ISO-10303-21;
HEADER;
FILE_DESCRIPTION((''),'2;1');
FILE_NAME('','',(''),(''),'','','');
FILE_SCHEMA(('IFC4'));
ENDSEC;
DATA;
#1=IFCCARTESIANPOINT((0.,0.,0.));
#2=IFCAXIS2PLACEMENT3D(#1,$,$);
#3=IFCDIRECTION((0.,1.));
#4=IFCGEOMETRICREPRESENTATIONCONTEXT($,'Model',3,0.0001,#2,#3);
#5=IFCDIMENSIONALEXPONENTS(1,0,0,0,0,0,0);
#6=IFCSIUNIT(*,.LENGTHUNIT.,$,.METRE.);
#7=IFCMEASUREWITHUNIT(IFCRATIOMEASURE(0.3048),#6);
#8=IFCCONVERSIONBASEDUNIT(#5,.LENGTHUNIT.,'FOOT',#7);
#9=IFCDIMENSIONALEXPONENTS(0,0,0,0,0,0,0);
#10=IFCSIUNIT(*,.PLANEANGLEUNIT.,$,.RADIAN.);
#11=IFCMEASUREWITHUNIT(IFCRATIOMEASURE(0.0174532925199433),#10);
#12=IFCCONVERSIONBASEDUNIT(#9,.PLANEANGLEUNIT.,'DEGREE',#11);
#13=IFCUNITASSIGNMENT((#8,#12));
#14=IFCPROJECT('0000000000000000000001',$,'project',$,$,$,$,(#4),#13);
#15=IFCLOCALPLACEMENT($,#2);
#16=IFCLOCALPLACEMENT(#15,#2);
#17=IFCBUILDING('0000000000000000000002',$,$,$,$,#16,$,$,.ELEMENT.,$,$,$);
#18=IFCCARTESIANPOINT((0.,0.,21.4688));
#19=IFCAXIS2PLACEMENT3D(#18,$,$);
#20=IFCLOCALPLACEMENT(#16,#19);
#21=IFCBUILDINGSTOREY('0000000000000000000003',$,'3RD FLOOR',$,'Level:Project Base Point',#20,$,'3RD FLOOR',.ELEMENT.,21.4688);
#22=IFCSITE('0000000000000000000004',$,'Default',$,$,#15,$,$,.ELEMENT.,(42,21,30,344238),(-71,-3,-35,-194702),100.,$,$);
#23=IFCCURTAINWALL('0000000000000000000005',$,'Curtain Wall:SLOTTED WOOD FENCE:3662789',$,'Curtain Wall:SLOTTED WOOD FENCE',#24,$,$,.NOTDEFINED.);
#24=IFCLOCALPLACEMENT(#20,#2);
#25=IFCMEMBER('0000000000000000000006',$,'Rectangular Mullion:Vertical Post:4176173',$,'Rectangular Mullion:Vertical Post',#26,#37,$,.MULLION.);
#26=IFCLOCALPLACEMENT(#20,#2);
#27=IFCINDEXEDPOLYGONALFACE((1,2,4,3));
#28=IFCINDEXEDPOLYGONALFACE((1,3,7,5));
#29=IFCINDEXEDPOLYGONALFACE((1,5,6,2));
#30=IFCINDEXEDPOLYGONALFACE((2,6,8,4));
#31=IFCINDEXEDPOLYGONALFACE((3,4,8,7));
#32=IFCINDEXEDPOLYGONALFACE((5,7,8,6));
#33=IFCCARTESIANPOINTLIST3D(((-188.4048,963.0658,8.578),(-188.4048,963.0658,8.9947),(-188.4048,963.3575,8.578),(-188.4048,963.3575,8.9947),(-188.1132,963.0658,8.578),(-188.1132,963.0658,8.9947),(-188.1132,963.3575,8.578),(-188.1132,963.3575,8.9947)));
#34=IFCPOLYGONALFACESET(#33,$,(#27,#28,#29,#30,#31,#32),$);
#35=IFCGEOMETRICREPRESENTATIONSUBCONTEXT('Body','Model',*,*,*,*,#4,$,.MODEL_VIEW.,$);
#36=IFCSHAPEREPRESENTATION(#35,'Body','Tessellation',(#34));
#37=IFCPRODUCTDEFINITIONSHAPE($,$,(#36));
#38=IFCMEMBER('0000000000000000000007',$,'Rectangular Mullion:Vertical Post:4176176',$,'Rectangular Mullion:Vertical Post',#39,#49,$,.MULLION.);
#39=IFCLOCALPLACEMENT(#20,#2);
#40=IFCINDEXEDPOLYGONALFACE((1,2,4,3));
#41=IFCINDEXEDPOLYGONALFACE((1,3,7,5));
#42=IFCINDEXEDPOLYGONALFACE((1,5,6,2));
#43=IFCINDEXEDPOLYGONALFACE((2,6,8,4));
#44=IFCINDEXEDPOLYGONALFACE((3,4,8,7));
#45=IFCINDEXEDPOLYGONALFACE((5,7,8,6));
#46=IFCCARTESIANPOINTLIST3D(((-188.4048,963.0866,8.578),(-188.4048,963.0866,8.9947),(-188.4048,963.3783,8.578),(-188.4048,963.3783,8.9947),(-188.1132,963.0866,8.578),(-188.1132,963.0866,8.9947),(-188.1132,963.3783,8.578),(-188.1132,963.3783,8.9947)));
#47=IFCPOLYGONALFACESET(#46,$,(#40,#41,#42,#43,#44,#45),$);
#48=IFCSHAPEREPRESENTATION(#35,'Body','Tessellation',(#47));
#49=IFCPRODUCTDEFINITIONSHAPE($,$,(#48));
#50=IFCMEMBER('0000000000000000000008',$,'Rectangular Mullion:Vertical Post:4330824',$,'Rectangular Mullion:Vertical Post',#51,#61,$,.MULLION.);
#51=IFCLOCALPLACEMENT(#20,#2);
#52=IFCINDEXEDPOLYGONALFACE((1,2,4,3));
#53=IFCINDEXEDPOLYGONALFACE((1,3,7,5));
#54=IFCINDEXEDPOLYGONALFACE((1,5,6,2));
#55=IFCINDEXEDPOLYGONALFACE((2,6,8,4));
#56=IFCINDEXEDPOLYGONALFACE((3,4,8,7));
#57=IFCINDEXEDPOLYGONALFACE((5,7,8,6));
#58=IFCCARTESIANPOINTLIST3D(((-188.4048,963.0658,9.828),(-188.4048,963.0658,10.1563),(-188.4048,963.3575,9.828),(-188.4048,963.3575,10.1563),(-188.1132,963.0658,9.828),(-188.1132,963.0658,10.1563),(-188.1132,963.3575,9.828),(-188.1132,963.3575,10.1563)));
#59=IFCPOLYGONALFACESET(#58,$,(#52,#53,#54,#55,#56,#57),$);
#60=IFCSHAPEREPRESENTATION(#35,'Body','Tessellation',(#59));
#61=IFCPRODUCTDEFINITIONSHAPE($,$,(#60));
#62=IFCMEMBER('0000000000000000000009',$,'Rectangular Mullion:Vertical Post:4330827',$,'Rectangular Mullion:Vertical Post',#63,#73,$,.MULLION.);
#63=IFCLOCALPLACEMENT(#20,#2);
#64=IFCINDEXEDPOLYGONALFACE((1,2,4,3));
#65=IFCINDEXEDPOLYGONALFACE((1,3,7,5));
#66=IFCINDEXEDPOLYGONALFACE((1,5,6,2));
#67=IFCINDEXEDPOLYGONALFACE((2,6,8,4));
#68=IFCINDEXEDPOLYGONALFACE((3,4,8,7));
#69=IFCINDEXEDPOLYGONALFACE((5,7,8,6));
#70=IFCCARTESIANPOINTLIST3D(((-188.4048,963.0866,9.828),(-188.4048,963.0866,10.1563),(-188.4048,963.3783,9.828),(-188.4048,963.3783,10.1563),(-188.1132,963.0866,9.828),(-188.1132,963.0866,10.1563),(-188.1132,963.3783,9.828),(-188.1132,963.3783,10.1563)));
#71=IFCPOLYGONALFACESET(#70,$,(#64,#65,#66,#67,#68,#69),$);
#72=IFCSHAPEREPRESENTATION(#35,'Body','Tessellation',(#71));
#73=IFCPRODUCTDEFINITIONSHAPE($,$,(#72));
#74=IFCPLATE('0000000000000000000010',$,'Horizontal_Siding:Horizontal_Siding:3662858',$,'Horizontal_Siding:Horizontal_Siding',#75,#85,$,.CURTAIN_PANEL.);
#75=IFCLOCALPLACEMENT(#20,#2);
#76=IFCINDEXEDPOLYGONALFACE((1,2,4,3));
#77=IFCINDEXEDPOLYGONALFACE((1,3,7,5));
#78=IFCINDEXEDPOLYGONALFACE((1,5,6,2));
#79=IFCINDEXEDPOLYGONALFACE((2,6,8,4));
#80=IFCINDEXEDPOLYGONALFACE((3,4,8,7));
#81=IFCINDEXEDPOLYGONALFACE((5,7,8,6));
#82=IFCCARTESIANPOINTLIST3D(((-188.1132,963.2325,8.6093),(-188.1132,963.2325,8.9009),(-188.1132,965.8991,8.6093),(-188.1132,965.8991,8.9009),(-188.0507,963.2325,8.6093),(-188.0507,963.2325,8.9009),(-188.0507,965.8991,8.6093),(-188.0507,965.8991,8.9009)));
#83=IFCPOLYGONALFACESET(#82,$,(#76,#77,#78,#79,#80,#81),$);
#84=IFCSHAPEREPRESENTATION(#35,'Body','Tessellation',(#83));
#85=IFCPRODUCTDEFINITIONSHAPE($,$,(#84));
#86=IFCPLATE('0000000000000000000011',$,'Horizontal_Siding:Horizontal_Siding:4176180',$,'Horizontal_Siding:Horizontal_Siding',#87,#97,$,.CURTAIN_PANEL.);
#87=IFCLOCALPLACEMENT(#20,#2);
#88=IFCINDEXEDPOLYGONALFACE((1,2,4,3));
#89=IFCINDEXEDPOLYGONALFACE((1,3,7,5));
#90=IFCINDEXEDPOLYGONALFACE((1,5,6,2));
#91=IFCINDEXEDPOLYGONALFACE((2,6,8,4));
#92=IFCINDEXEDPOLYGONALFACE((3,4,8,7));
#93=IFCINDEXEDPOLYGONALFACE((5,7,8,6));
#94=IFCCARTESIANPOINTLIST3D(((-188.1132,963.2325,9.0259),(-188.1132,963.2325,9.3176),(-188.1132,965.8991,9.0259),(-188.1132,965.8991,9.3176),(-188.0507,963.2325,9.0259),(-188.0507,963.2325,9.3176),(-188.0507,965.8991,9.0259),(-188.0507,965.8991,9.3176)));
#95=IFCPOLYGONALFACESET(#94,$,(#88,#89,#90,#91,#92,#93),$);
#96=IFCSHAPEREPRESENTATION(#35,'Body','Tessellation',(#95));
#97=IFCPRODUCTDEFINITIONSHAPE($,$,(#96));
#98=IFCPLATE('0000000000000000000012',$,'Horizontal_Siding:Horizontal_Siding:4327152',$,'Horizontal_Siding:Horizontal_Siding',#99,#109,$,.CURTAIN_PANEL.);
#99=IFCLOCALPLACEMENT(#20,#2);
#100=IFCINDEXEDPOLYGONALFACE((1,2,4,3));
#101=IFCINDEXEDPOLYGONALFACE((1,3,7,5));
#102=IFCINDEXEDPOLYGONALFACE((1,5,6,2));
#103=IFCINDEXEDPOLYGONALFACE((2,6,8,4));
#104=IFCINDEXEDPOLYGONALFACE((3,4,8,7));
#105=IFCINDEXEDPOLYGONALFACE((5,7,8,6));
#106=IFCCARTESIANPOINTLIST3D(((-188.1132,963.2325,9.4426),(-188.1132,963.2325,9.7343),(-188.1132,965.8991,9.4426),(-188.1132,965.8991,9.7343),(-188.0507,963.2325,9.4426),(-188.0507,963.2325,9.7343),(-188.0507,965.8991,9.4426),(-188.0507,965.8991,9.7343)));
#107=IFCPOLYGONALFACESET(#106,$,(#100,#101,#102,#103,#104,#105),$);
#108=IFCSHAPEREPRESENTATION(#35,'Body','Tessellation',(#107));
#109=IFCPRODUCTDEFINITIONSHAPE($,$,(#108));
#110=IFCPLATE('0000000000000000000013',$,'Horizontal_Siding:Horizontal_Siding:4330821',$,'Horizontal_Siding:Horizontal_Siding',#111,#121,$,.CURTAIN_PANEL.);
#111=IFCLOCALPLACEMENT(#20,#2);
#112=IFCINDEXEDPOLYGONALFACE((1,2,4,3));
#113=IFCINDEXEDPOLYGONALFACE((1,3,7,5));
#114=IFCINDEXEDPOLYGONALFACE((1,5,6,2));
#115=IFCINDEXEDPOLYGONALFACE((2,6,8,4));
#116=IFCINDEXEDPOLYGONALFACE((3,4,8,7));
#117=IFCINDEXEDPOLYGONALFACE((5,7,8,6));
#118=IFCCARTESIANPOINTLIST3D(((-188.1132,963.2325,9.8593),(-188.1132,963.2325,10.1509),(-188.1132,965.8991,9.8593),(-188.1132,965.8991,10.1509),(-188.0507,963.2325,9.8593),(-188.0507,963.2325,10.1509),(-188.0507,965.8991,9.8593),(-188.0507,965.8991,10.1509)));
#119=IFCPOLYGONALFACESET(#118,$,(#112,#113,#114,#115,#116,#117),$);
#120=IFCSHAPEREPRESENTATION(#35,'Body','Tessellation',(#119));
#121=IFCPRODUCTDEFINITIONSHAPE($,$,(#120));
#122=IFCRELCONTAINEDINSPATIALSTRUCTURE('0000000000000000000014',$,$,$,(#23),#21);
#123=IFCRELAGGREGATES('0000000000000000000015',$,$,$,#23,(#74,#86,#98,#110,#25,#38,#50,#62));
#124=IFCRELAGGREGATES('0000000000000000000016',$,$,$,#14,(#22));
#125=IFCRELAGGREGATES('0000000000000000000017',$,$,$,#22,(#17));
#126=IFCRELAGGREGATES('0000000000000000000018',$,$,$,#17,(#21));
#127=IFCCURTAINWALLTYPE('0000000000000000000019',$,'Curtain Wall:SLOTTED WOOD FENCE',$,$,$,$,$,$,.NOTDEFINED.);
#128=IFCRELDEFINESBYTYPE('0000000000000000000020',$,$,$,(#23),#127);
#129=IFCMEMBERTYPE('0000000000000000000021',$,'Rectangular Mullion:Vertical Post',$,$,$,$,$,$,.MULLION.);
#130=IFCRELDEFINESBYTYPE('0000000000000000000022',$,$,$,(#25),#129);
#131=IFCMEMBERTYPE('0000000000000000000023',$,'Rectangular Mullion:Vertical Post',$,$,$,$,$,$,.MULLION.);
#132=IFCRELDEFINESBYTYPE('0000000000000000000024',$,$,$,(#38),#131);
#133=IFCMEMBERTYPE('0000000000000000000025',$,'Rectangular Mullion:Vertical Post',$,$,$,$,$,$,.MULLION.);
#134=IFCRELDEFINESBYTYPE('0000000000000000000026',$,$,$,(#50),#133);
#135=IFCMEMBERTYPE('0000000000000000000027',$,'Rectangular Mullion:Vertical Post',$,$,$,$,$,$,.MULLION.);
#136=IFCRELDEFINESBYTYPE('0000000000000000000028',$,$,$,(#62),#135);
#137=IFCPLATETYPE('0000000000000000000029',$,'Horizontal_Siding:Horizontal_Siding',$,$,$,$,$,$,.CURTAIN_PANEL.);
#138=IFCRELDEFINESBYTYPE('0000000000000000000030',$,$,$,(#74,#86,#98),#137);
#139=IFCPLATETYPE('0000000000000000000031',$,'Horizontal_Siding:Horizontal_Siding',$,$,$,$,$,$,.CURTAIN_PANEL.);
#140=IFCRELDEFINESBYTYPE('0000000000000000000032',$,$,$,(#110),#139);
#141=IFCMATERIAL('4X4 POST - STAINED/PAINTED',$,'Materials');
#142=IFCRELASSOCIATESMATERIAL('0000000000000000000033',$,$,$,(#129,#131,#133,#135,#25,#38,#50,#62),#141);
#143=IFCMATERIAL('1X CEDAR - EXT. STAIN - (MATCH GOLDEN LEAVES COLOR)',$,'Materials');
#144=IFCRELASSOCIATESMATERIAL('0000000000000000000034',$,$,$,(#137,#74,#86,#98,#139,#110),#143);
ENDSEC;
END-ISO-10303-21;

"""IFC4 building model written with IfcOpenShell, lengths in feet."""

from ifc_helpers import new_model, entity, si_unit, converted_unit, direction, frame, frame_2d, origin, origin_2d_with_axis, place, context, subcontext, project, spatial, rectangle, extrude, source, transform, mapped, material, material_profile, profile_set, profile_usage, type_object, type_shapes, element, aggregate, save


model = new_model("IFC4")

# Units and contexts
model_context = context("Model", 3, precision=0.0001, world=origin(), true_north=direction((0.0, 1.0)))
body_context = subcontext(model_context, "Body", "Model", "MODEL_VIEW")
ifc_project = project(units=[converted_unit("LENGTHUNIT", "FOOT", entity("IfcRatioMeasure", 0.3048), si_unit("LENGTHUNIT", "METRE"), dimensions=[1, 0, 0, 0, 0, 0, 0]), converted_unit("PLANEANGLEUNIT", "DEGREE", entity("IfcRatioMeasure", 0.0174532925199433), si_unit("PLANEANGLEUNIT", "RADIAN"), dimensions=[0, 0, 0, 0, 0, 0, 0])], contexts=[model_context])

# Site, building, storey
site_placement = place(None, origin())
site = spatial("IfcSite", under=ifc_project, at=site_placement, Name="Default", CompositionType="ELEMENT", RefLatitude=(42, 21, 30, 344238), RefLongitude=(-71, -3, -35, -194702), RefElevation=100.0)
building_placement = place(site_placement, origin())
building = spatial("IfcBuilding", under=site, at=building_placement, CompositionType="ELEMENT")
storey_placement = place(building_placement, frame((0.0, 0.0, 21.4688)))
storey = spatial("IfcBuildingStorey", under=building, at=storey_placement, Name="3RD FLOOR", ObjectType="Level:Project Base Point", LongName="3RD FLOOR", CompositionType="ELEMENT", Elevation=21.4688)

# Curtain wall, members, plates
curtain_wall_type = type_object("IfcCurtainWallType", Name="Curtain Wall:SLOTTED WOOD FENCE", PredefinedType="NOTDEFINED")
curtain_wall_placement = place(storey_placement, frame((0.0, 0.0, -21.4688)))
curtain_wall = element("IfcCurtainWall", 1, at=curtain_wall_placement, inside=storey, type_object=curtain_wall_type, Name="Curtain Wall:SLOTTED WOOD FENCE:3662789", ObjectType="Curtain Wall:SLOTTED WOOD FENCE", PredefinedType="NOTDEFINED")
ifc_material_1 = material(Name="4X4 POST - STAINED/PAINTED", Category="Materials")
ifc_material_profile = material_profile(ifc_material_1, rectangle(XDim=0.2917, YDim=0.2917, at=origin_2d_with_axis()), Name="Vertical Post")
ifc_profile_set = profile_set([ifc_material_profile], Name="Vertical Post")
ifc_profile_usage_1 = profile_usage(ifc_profile_set)
member_type_1 = type_object("IfcMemberType", Name="Rectangular Mullion:Vertical Post", PredefinedType="MULLION", material=ifc_profile_set)
shared_shape_1 = source(origin(), body_context, "Body", "SweptSolid", [
    extrude(rectangle(XDim=0.2917, YDim=0.2917, at=frame_2d((0.0, 0.0), x_axis=(1.0, 0.0))), frame((-0.1458, 0.2083, -0.4167), z_axis=(0.0, 0.0, 1.0), x_axis=(0.0, -1.0, 0.0)), (0.0, 0.0, 1.0), 0.4167),
])
type_shapes(member_type_1, [shared_shape_1])
member_1_placement = place(storey_placement, frame((-188.0507, 963.0658, 8.578), z_axis=(0.0, 0.0, -1.0), x_axis=(0.0, -1.0, 0.0)))
member_1 = element("IfcMember", 2, at=member_1_placement, type_object=member_type_1, material=ifc_profile_usage_1, Name="Rectangular Mullion:Vertical Post:4176173", ObjectType="Rectangular Mullion:Vertical Post", PredefinedType="MULLION", context=body_context, shape_type="MappedRepresentation", body=[
    mapped(shared_shape_1, transform((0.0, 0.0, 0.0), scale=1.0)),
])
ifc_profile_usage_2 = profile_usage(ifc_profile_set)
member_type_2 = type_object("IfcMemberType", Name="Rectangular Mullion:Vertical Post", PredefinedType="MULLION", material=ifc_profile_set)
shared_shape_2 = source(origin(), body_context, "Body", "SweptSolid", [
    extrude(rectangle(XDim=0.2917, YDim=0.2917, at=origin_2d_with_axis()), frame((0.0, 0.2083, -0.4167), z_axis=(0.0, 0.0, 1.0), x_axis=(0.0, -1.0, 0.0)), (0.0, 0.0, 1.0), 0.4167),
])
type_shapes(member_type_2, [shared_shape_2])
member_2_placement = place(storey_placement, frame((-188.0507, 963.2325, 8.578), z_axis=(0.0, 0.0, -1.0), x_axis=(0.0, -1.0, 0.0)))
member_2 = element("IfcMember", 3, at=member_2_placement, type_object=member_type_2, material=ifc_profile_usage_2, Name="Rectangular Mullion:Vertical Post:4176176", ObjectType="Rectangular Mullion:Vertical Post", PredefinedType="MULLION", context=body_context, shape_type="MappedRepresentation", body=[
    mapped(shared_shape_2, transform((0.0, 0.0, 0.0), scale=1.0)),
])
ifc_profile_usage_3 = profile_usage(ifc_profile_set)
member_type_3 = type_object("IfcMemberType", Name="Rectangular Mullion:Vertical Post", PredefinedType="MULLION", material=ifc_profile_set)
shared_shape_3 = source(origin(), body_context, "Body", "SweptSolid", [
    extrude(rectangle(XDim=0.2917, YDim=0.2917, at=origin_2d_with_axis()), frame((-0.1458, 0.2083, -0.3282), z_axis=(0.0, 0.0, 1.0), x_axis=(0.0, -1.0, 0.0)), (0.0, 0.0, 1.0), 0.3282),
])
type_shapes(member_type_3, [shared_shape_3])
member_3_placement = place(storey_placement, frame((-188.0507, 963.0658, 9.828), z_axis=(0.0, 0.0, -1.0), x_axis=(0.0, -1.0, 0.0)))
member_3 = element("IfcMember", 4, at=member_3_placement, type_object=member_type_3, material=ifc_profile_usage_3, Name="Rectangular Mullion:Vertical Post:4330824", ObjectType="Rectangular Mullion:Vertical Post", PredefinedType="MULLION", context=body_context, shape_type="MappedRepresentation", body=[
    mapped(shared_shape_3, transform((0.0, 0.0, 0.0), scale=1.0)),
])
ifc_profile_usage_4 = profile_usage(ifc_profile_set)
member_type_4 = type_object("IfcMemberType", Name="Rectangular Mullion:Vertical Post", PredefinedType="MULLION", material=ifc_profile_set)
shared_shape_4 = source(origin(), body_context, "Body", "SweptSolid", [
    extrude(rectangle(XDim=0.2917, YDim=0.2917, at=origin_2d_with_axis()), frame((0.0, 0.2083, -0.3282), z_axis=(0.0, 0.0, 1.0), x_axis=(0.0, -1.0, 0.0)), (0.0, 0.0, 1.0), 0.3282),
])
type_shapes(member_type_4, [shared_shape_4])
member_4_placement = place(storey_placement, frame((-188.0507, 963.2325, 9.828), z_axis=(0.0, 0.0, -1.0), x_axis=(0.0, -1.0, 0.0)))
member_4 = element("IfcMember", 5, at=member_4_placement, type_object=member_type_4, material=ifc_profile_usage_4, Name="Rectangular Mullion:Vertical Post:4330827", ObjectType="Rectangular Mullion:Vertical Post", PredefinedType="MULLION", context=body_context, shape_type="MappedRepresentation", body=[
    mapped(shared_shape_4, transform((0.0, 0.0, 0.0), scale=1.0)),
])
ifc_material_2 = material(Name="1X CEDAR - EXT. STAIN - (MATCH GOLDEN LEAVES COLOR)", Category="Materials")
plate_type_1 = type_object("IfcPlateType", Name="Horizontal_Siding:Horizontal_Siding", PredefinedType="CURTAIN_PANEL", material=ifc_material_2)
shared_shape_5 = source(origin(), body_context, "Body", "SweptSolid", [
    extrude(rectangle(XDim=0.0625, YDim=2.6667, at=origin_2d_with_axis()), frame((1.3333, 0.0312, 0.0), z_axis=(0.0, 0.0, 1.0), x_axis=(0.0, 1.0, 0.0)), (0.0, 0.0, 1.0), 0.2917),
])
type_shapes(plate_type_1, [shared_shape_5])
plate_1_placement = place(curtain_wall_placement, frame((-188.1132, 965.8991, 30.078), z_axis=(0.0, 0.0, 1.0), x_axis=(0.0, -1.0, 0.0)))
plate_1 = element("IfcPlate", 6, at=plate_1_placement, type_object=plate_type_1, material=ifc_material_2, Name="Horizontal_Siding:Horizontal_Siding:3662858", ObjectType="Horizontal_Siding:Horizontal_Siding", PredefinedType="CURTAIN_PANEL", context=body_context, shape_type="MappedRepresentation", body=[
    mapped(shared_shape_5, transform((0.0, 0.0, 0.0), scale=1.0)),
])
plate_2_placement = place(curtain_wall_placement, frame((-188.1132, 965.8991, 30.4947), z_axis=(0.0, 0.0, 1.0), x_axis=(0.0, -1.0, 0.0)))
plate_2 = element("IfcPlate", 7, at=plate_2_placement, type_object=plate_type_1, material=ifc_material_2, Name="Horizontal_Siding:Horizontal_Siding:4176180", ObjectType="Horizontal_Siding:Horizontal_Siding", PredefinedType="CURTAIN_PANEL", context=body_context, shape_type="MappedRepresentation", body=[
    mapped(shared_shape_5, transform((0.0, 0.0, 0.0), scale=1.0)),
])
plate_3_placement = place(curtain_wall_placement, frame((-188.1132, 965.8991, 30.9113), z_axis=(0.0, 0.0, 1.0), x_axis=(0.0, -1.0, 0.0)))
plate_3 = element("IfcPlate", 8, at=plate_3_placement, type_object=plate_type_1, material=ifc_material_2, Name="Horizontal_Siding:Horizontal_Siding:4327152", ObjectType="Horizontal_Siding:Horizontal_Siding", PredefinedType="CURTAIN_PANEL", context=body_context, shape_type="MappedRepresentation", body=[
    mapped(shared_shape_5, transform((0.0, 0.0, 0.0), scale=1.0)),
])
plate_type_2 = type_object("IfcPlateType", Name="Horizontal_Siding:Horizontal_Siding", PredefinedType="CURTAIN_PANEL", material=ifc_material_2)
shared_shape_6 = source(origin(), body_context, "Body", "SweptSolid", [
    extrude(rectangle(XDim=0.0625, YDim=2.6667, at=origin_2d_with_axis()), frame((1.3333, 0.0312, 0.0), z_axis=(0.0, 0.0, 1.0), x_axis=(0.0, 1.0, 0.0)), (0.0, 0.0, 1.0), 0.2917),
])
type_shapes(plate_type_2, [shared_shape_6])
plate_4_placement = place(curtain_wall_placement, frame((-188.1132, 965.8991, 31.328), z_axis=(0.0, 0.0, 1.0), x_axis=(0.0, -1.0, 0.0)))
plate_4 = element("IfcPlate", 9, at=plate_4_placement, type_object=plate_type_2, material=ifc_material_2, Name="Horizontal_Siding:Horizontal_Siding:4330821", ObjectType="Horizontal_Siding:Horizontal_Siding", PredefinedType="CURTAIN_PANEL", context=body_context, shape_type="MappedRepresentation", body=[
    mapped(shared_shape_6, transform((0.0, 0.0, 0.0), scale=1.0)),
])
aggregate(curtain_wall, [plate_1, plate_2, plate_3, plate_4, member_1, member_2, member_3, member_4])

save(model, "model.ifc")
